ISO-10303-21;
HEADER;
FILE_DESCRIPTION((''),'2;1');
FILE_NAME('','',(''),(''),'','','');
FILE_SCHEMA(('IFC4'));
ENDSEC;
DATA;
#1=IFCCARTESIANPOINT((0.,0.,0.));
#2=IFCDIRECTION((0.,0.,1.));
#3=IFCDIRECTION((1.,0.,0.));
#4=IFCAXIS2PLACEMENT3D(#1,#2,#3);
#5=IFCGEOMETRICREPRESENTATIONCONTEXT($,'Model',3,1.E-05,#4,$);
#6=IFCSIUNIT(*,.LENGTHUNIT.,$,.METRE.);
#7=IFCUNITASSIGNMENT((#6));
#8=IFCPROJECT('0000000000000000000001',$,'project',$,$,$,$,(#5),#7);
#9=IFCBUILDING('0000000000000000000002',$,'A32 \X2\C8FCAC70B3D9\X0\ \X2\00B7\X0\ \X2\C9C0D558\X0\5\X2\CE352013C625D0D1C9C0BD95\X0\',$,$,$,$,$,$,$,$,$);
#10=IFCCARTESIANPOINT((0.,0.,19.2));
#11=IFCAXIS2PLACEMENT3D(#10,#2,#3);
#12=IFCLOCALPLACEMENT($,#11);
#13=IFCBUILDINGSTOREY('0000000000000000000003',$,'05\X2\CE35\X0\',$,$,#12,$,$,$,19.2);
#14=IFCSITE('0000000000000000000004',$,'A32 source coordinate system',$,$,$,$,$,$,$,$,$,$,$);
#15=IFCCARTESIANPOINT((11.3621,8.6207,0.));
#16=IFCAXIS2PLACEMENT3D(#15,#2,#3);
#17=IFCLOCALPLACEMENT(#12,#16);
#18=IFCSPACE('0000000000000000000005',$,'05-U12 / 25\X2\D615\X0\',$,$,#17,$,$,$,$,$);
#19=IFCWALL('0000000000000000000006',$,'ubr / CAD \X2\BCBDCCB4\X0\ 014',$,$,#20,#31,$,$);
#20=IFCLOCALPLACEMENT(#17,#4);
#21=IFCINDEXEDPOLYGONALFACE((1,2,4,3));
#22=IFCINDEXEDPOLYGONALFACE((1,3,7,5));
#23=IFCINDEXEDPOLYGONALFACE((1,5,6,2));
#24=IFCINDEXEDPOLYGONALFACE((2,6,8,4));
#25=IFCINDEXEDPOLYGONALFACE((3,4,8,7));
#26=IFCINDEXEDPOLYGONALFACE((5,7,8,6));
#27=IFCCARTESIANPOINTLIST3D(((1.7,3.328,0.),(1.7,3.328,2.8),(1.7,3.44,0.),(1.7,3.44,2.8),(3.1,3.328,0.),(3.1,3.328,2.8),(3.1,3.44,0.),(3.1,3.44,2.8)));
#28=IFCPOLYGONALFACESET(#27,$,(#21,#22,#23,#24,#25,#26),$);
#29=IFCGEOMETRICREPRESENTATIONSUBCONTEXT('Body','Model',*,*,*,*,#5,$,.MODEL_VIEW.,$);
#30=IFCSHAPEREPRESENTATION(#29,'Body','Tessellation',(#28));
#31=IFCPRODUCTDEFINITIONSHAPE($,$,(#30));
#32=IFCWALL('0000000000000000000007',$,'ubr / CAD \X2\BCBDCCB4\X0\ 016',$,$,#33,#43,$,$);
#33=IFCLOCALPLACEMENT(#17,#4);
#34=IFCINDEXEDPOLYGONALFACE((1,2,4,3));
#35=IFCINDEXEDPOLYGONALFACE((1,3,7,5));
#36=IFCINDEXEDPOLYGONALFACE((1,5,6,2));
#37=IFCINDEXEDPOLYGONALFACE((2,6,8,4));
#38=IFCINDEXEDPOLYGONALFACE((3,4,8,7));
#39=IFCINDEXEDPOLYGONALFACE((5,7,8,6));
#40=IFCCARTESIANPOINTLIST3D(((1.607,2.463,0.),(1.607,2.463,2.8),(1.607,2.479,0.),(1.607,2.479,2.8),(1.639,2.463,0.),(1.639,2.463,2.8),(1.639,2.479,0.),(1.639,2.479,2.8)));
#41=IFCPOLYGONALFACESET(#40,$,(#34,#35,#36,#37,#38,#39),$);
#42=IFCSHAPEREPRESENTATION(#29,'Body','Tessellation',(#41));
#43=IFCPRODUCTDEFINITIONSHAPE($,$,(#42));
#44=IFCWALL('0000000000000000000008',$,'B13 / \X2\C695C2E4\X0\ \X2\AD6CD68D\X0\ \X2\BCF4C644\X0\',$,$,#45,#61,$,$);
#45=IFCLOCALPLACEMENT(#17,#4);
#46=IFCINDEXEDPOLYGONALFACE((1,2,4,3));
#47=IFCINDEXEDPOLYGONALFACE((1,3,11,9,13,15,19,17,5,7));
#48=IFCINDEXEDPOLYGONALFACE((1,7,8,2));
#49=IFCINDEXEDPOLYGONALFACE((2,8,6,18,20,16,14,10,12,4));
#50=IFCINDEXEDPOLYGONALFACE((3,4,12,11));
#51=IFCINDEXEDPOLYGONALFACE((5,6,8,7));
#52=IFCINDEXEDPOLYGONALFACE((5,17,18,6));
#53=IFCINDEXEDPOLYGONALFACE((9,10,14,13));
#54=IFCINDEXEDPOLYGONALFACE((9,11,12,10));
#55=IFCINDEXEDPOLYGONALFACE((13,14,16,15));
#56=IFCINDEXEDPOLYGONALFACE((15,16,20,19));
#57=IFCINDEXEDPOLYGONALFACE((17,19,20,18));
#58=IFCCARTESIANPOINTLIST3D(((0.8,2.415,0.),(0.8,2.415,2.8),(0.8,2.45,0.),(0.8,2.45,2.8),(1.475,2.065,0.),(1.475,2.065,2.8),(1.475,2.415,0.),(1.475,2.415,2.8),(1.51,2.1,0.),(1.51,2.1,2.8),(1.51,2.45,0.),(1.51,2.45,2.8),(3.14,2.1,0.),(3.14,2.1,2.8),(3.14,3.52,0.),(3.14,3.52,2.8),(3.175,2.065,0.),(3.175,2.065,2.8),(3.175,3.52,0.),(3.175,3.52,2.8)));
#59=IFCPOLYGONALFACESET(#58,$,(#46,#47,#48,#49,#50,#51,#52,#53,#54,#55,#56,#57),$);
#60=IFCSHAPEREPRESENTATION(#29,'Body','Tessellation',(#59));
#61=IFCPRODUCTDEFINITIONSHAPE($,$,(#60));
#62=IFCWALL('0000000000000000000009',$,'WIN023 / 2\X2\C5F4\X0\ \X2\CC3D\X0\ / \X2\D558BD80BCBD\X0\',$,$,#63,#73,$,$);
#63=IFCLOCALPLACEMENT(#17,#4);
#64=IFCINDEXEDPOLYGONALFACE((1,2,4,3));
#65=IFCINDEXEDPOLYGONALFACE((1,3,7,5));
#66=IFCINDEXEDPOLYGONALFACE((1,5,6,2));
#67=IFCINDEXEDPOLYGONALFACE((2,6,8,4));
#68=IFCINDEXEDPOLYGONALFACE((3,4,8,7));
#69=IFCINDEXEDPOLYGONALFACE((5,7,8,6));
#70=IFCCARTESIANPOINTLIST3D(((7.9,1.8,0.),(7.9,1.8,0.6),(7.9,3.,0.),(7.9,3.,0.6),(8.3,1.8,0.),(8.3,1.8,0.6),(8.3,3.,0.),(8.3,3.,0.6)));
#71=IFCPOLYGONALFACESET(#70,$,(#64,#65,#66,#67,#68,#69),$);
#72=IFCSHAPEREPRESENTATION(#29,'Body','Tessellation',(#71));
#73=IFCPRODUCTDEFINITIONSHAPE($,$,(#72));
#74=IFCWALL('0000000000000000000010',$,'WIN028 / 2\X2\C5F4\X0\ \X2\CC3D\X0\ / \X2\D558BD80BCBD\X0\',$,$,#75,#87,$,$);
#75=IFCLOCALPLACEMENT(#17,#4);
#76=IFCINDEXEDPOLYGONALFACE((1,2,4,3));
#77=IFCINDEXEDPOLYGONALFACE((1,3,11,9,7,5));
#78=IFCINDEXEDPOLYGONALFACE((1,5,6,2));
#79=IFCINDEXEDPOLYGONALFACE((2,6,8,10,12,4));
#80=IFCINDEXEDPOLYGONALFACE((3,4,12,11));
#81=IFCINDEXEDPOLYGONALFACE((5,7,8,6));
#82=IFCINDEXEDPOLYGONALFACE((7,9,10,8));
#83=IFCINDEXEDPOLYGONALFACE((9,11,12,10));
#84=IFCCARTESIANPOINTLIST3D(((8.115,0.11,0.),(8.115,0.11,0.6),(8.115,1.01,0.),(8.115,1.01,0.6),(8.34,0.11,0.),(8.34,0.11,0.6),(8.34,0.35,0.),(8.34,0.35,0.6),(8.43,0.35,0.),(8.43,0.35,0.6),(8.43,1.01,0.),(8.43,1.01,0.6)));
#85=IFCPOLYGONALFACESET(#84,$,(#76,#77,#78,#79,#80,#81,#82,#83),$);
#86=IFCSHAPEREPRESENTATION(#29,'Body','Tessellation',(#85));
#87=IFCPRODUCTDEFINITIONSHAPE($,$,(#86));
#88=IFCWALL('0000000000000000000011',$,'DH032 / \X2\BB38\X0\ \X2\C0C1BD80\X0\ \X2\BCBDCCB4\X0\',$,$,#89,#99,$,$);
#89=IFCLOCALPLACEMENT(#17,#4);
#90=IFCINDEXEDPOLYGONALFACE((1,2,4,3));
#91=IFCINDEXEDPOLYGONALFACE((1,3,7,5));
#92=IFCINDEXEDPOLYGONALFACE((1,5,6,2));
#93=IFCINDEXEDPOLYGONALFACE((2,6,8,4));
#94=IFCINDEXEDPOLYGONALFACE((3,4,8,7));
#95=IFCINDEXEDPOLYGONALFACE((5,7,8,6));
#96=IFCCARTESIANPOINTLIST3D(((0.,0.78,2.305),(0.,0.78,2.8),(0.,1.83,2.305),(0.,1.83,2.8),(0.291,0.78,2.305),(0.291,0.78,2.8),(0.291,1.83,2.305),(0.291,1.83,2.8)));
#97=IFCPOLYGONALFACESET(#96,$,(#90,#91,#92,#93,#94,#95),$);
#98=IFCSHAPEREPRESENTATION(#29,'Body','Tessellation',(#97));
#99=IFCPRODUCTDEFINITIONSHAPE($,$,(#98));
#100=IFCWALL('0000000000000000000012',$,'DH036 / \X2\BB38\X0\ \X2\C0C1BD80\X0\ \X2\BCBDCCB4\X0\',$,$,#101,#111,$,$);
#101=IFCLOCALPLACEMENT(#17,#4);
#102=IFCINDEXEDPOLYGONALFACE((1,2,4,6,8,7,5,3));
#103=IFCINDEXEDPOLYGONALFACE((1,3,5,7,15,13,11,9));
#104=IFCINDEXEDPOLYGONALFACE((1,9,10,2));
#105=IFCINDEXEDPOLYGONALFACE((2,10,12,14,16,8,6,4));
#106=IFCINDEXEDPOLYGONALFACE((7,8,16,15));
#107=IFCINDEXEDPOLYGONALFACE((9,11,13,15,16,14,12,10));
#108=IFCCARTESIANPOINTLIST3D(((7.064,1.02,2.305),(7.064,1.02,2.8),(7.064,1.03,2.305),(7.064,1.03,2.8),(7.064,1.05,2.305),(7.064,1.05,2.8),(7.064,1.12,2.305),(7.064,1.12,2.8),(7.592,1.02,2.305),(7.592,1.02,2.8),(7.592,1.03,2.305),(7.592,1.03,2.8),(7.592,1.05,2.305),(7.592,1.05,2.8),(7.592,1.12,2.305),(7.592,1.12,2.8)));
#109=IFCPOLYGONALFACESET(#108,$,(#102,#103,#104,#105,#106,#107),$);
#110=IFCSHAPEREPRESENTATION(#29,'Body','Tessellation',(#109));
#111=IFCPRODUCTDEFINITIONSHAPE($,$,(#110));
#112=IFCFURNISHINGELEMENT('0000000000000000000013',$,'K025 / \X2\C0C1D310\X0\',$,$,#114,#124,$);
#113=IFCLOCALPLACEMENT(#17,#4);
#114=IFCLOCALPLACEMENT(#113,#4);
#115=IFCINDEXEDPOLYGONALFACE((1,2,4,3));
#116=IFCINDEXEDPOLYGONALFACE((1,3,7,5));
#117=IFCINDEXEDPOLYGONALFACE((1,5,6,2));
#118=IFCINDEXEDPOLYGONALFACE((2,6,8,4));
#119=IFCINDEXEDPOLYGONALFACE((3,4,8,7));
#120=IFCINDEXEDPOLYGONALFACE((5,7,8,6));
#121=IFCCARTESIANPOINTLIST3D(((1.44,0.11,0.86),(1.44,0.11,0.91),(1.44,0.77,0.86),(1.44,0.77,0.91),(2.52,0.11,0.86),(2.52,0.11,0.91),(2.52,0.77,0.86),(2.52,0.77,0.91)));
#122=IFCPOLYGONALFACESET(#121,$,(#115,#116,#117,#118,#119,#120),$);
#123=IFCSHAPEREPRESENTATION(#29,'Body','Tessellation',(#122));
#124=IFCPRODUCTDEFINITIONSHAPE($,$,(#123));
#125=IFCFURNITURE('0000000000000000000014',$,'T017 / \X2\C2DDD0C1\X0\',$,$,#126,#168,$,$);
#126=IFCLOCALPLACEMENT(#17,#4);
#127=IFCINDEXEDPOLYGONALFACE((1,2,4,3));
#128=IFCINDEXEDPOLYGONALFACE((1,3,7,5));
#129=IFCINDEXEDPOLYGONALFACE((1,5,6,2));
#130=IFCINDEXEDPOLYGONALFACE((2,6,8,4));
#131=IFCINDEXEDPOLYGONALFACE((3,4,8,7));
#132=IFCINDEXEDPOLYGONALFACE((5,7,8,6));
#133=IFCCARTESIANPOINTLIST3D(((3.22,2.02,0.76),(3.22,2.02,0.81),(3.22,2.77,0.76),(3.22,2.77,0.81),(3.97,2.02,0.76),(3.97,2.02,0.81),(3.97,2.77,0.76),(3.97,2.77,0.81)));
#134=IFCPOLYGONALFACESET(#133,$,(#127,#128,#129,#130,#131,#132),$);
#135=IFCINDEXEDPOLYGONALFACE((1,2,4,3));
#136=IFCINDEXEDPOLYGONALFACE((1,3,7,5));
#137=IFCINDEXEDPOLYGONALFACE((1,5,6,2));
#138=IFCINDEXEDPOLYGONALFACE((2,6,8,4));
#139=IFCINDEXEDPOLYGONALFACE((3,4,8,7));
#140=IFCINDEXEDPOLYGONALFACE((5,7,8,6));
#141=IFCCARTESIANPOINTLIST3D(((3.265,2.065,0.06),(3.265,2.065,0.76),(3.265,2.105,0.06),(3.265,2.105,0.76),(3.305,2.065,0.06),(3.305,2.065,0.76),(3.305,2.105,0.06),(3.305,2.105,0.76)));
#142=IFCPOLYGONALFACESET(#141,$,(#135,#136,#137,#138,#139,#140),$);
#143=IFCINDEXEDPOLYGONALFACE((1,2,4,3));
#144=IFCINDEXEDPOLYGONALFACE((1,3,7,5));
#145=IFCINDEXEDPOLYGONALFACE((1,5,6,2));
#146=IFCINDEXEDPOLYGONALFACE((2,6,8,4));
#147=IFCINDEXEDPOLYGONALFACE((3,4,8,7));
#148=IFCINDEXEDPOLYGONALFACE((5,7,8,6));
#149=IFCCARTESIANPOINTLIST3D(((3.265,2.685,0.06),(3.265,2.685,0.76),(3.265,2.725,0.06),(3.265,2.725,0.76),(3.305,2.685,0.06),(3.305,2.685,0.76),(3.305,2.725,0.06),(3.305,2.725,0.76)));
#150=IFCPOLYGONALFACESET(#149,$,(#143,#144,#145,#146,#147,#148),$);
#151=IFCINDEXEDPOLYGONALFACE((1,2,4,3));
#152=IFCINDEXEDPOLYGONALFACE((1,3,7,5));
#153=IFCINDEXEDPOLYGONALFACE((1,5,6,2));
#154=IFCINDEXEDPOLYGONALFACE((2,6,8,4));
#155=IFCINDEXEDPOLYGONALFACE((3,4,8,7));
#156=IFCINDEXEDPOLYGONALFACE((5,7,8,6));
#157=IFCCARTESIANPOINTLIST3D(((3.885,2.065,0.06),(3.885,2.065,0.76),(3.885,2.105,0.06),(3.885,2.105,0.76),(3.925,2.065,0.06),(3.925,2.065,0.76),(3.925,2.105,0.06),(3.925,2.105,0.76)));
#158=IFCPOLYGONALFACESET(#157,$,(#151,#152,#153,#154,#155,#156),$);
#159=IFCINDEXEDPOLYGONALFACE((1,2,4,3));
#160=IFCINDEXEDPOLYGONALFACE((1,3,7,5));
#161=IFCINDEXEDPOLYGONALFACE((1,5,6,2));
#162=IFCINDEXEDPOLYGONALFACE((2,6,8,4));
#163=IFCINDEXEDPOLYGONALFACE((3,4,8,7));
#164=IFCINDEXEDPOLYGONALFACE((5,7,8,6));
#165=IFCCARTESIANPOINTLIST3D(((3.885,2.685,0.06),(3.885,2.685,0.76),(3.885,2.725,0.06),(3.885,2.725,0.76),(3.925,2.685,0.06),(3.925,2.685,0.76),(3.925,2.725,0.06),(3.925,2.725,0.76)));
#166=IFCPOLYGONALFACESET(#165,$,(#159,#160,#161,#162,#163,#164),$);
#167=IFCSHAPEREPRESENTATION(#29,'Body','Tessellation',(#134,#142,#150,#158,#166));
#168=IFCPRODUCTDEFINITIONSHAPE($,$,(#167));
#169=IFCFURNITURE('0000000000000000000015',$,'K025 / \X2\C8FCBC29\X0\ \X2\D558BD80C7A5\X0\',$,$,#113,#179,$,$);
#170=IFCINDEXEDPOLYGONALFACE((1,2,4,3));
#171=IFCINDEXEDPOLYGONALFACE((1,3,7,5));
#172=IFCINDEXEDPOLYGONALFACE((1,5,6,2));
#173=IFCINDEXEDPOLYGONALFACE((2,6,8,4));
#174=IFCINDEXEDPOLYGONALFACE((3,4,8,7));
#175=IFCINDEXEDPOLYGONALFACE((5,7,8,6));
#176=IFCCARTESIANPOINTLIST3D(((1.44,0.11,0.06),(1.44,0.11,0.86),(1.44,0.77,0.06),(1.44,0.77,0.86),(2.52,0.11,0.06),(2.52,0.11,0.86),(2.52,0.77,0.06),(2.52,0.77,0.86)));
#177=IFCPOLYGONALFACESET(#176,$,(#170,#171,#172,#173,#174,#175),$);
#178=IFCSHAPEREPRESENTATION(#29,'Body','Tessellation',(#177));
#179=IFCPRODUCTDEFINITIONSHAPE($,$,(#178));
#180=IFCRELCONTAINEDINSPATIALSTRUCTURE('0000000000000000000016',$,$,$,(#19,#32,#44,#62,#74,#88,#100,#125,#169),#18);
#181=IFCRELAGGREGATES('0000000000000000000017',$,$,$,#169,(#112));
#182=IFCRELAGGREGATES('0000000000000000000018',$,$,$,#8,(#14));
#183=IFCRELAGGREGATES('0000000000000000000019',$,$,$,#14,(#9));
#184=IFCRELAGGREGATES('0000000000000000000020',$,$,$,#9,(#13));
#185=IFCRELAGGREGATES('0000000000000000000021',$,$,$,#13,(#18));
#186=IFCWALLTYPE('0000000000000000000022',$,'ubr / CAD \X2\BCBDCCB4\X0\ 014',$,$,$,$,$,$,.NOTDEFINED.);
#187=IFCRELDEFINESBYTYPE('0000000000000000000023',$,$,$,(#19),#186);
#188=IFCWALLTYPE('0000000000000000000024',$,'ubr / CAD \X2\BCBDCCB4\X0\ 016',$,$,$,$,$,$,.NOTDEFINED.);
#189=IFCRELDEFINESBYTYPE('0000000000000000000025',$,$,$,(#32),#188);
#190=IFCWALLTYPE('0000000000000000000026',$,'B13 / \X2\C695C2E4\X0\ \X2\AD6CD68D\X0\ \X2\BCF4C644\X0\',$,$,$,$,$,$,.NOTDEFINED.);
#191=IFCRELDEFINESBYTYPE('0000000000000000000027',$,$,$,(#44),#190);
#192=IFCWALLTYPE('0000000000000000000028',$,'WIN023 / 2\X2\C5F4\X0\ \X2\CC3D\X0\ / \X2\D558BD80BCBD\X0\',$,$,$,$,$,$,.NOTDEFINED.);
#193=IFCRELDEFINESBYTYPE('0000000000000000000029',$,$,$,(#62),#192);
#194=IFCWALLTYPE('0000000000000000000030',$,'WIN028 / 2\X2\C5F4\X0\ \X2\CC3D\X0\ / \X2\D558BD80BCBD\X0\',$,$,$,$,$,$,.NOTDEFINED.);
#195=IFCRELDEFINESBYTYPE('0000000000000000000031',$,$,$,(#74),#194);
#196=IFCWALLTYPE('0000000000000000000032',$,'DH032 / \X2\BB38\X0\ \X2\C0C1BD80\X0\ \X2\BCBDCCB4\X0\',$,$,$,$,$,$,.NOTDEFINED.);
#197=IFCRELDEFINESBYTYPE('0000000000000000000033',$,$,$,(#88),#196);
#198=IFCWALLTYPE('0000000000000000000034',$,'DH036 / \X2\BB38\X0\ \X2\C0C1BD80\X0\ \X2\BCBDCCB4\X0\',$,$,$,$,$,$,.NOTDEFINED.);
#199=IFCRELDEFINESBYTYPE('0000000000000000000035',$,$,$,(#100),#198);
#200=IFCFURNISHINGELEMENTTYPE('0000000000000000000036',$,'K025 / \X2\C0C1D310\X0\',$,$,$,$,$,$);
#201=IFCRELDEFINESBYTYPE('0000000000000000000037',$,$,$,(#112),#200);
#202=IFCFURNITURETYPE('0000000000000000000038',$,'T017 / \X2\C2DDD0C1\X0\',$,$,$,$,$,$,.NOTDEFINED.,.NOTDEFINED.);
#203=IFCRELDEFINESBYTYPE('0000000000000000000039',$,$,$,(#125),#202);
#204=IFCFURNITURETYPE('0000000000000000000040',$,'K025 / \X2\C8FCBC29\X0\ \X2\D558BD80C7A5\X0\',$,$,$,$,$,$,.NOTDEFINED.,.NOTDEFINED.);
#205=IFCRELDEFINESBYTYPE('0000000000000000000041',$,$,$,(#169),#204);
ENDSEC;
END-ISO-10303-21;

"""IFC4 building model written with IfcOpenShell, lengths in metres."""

from ifc_helpers import new_model, si_unit, frame, origin, origin_with_axes, place, context, subcontext, project, spatial, polyline, outline, extrude, source, transform, mapped, type_object, type_shapes, element, aggregate, save


model = new_model("IFC4")

# Units and contexts
model_context = context("Model", 3, precision=1e-05, world=origin_with_axes())
body_context = subcontext(model_context, "Body", "Model", "MODEL_VIEW")
ifc_project = project(units=[si_unit("LENGTHUNIT", "METRE")], contexts=[model_context])

# Site, building, storey, space
site = spatial("IfcSite", under=ifc_project, Name="A32 source coordinate system")
building = spatial("IfcBuilding", under=site, Name="A32 주거동 · 지하5층–옥탑지붕")
storey_placement = place(None, frame((0.0, 0.0, 19.2), z_axis=(0.0, 0.0, 1.0), x_axis=(1.0, 0.0, 0.0)))
storey = spatial("IfcBuildingStorey", under=building, at=storey_placement, Name="05층", Elevation=19.2)
space_1_placement = place(storey_placement, frame((11.3621, 8.6207, 0.0), z_axis=(0.0, 0.0, 1.0), x_axis=(1.0, 0.0, 0.0)))
space_1 = spatial("IfcSpace", under=storey, at=space_1_placement, Name="05-U12 / 25형")

# Walls
wall_type_1 = type_object("IfcWallType", Name="ubr / CAD 벽체 014", PredefinedType="NOTDEFINED")
shared_shape_1 = source(origin(), body_context, "Body", "SweptSolid", [
    extrude(outline(polyline([(3.1, 3.44), (3.1, 3.328), (1.7, 3.328), (1.7, 3.44), (3.1, 3.44)])), origin(), (0.0, 0.0, 1.0), 2.8),
])
type_shapes(wall_type_1, [shared_shape_1])
wall_1_placement = place(space_1_placement, origin_with_axes())
element("IfcWall", 1, at=wall_1_placement, inside=space_1, type_object=wall_type_1, Name="ubr / CAD 벽체 014", context=body_context, shape_type="MappedRepresentation", body=[
    mapped(shared_shape_1, transform((0.0, 0.0, 0.0), scale=1.0)),
])
wall_type_2 = type_object("IfcWallType", Name="ubr / CAD 벽체 016", PredefinedType="NOTDEFINED")
shared_shape_2 = source(origin(), body_context, "Body", "SweptSolid", [
    extrude(outline(polyline([(1.639, 2.479), (1.639, 2.463), (1.607, 2.463), (1.607, 2.479), (1.639, 2.479)])), origin(), (0.0, 0.0, 1.0), 2.8),
])
type_shapes(wall_type_2, [shared_shape_2])
wall_2_placement = place(space_1_placement, origin_with_axes())
element("IfcWall", 2, at=wall_2_placement, inside=space_1, type_object=wall_type_2, Name="ubr / CAD 벽체 016", context=body_context, shape_type="MappedRepresentation", body=[
    mapped(shared_shape_2, transform((0.0, 0.0, 0.0), scale=1.0)),
])
wall_type_3 = type_object("IfcWallType", Name="B13 / 욕실 구획 보완", PredefinedType="NOTDEFINED")
shared_shape_3 = source(origin(), body_context, "Body", "SweptSolid", [
    extrude(outline(polyline([(0.8, 2.45), (1.51, 2.45), (1.51, 2.1), (3.14, 2.1), (3.14, 3.52), (3.175, 3.52), (3.175, 2.065), (1.475, 2.065), (1.475, 2.415), (0.8, 2.415), (0.8, 2.45)])), origin(), (0.0, 0.0, 1.0), 2.8),
])
type_shapes(wall_type_3, [shared_shape_3])
wall_3_placement = place(space_1_placement, origin_with_axes())
element("IfcWall", 3, at=wall_3_placement, inside=space_1, type_object=wall_type_3, Name="B13 / 욕실 구획 보완", context=body_context, shape_type="MappedRepresentation", body=[
    mapped(shared_shape_3, transform((0.0, 0.0, 0.0), scale=1.0)),
])
wall_type_4 = type_object("IfcWallType", Name="WIN023 / 2열 창 / 하부벽", PredefinedType="NOTDEFINED")
shared_shape_4 = source(origin(), body_context, "Body", "SweptSolid", [
    extrude(outline(polyline([(7.9, 1.8), (7.9, 3.0), (8.3, 3.0), (8.3, 1.8), (7.9, 1.8)])), origin(), (0.0, 0.0, 1.0), 0.6),
])
type_shapes(wall_type_4, [shared_shape_4])
wall_4_placement = place(space_1_placement, origin_with_axes())
element("IfcWall", 4, at=wall_4_placement, inside=space_1, type_object=wall_type_4, Name="WIN023 / 2열 창 / 하부벽", context=body_context, shape_type="MappedRepresentation", body=[
    mapped(shared_shape_4, transform((0.0, 0.0, 0.0), scale=1.0)),
])
wall_type_5 = type_object("IfcWallType", Name="WIN028 / 2열 창 / 하부벽", PredefinedType="NOTDEFINED")
shared_shape_5 = source(origin(), body_context, "Body", "SweptSolid", [
    extrude(outline(polyline([(8.34, 0.35), (8.34, 0.11), (8.115, 0.11), (8.115, 1.01), (8.43, 1.01), (8.43, 0.35), (8.34, 0.35)])), origin(), (0.0, 0.0, 1.0), 0.6),
])
type_shapes(wall_type_5, [shared_shape_5])
wall_5_placement = place(space_1_placement, origin_with_axes())
element("IfcWall", 5, at=wall_5_placement, inside=space_1, type_object=wall_type_5, Name="WIN028 / 2열 창 / 하부벽", context=body_context, shape_type="MappedRepresentation", body=[
    mapped(shared_shape_5, transform((0.0, 0.0, 0.0), scale=1.0)),
])
wall_type_6 = type_object("IfcWallType", Name="DH032 / 문 상부 벽체", PredefinedType="NOTDEFINED")
shared_shape_6 = source(origin(), body_context, "Body", "SweptSolid", [
    extrude(outline(polyline([(0.0, 1.83), (0.291, 1.83), (0.291, 0.78), (0.0, 0.78), (0.0, 1.83)])), frame((0.0, 0.0, 2.305)), (0.0, 0.0, 1.0), 0.495),
])
type_shapes(wall_type_6, [shared_shape_6])
wall_6_placement = place(space_1_placement, origin_with_axes())
element("IfcWall", 6, at=wall_6_placement, inside=space_1, type_object=wall_type_6, Name="DH032 / 문 상부 벽체", context=body_context, shape_type="MappedRepresentation", body=[
    mapped(shared_shape_6, transform((0.0, 0.0, 0.0), scale=1.0)),
])
wall_type_7 = type_object("IfcWallType", Name="DH036 / 문 상부 벽체", PredefinedType="NOTDEFINED")
shared_shape_7 = source(origin(), body_context, "Body", "SweptSolid", [
    extrude(outline(polyline([(7.064, 1.03), (7.064, 1.05), (7.064, 1.12), (7.592, 1.12), (7.592, 1.05), (7.592, 1.03), (7.592, 1.02), (7.064, 1.02), (7.064, 1.03)])), frame((0.0, 0.0, 2.305)), (0.0, 0.0, 1.0), 0.495),
])
type_shapes(wall_type_7, [shared_shape_7])
wall_7_placement = place(space_1_placement, origin_with_axes())
element("IfcWall", 7, at=wall_7_placement, inside=space_1, type_object=wall_type_7, Name="DH036 / 문 상부 벽체", context=body_context, shape_type="MappedRepresentation", body=[
    mapped(shared_shape_7, transform((0.0, 0.0, 0.0), scale=1.0)),
])

# Furnishing element
furnishing_element_type_1 = type_object("IfcFurnishingElementType", Name="K025 / 상판")
shared_shape_8 = source(origin(), body_context, "Body", "SweptSolid", [
    extrude(outline(polyline([(2.52, 0.77), (2.52, 0.11), (1.44, 0.11), (1.44, 0.77), (2.52, 0.77)])), frame((0.0, 0.0, 0.86)), (0.0, 0.0, 1.0), 0.05),
])
type_shapes(furnishing_element_type_1, [shared_shape_8])
furniture_1_placement = place(space_1_placement, origin_with_axes())
furnishing_1_placement = place(furniture_1_placement, origin_with_axes())
furnishing_1 = element("IfcFurnishingElement", 8, at=furnishing_1_placement, type_object=furnishing_element_type_1, Name="K025 / 상판", context=body_context, shape_type="MappedRepresentation", body=[
    mapped(shared_shape_8, transform((0.0, 0.0, 0.0), scale=1.0)),
])

# Furniture
furniture_type_1 = type_object("IfcFurnitureType", Name="T017 / 식탁", AssemblyPlace="NOTDEFINED", PredefinedType="NOTDEFINED")
shared_shape_9 = source(origin(), body_context, "Body", "SweptSolid", [
    extrude(outline(polyline([(3.97, 2.02), (3.22, 2.02), (3.22, 2.77), (3.97, 2.77), (3.97, 2.02)])), frame((0.0, 0.0, 0.76)), (0.0, 0.0, 1.0), 0.05),
    extrude(outline(polyline([(3.265, 2.065), (3.265, 2.105), (3.305, 2.105), (3.305, 2.065), (3.265, 2.065)])), frame((0.0, 0.0, 0.06)), (0.0, 0.0, 1.0), 0.7),
    extrude(outline(polyline([(3.265, 2.685), (3.265, 2.725), (3.305, 2.725), (3.305, 2.685), (3.265, 2.685)])), frame((0.0, 0.0, 0.06)), (0.0, 0.0, 1.0), 0.7),
    extrude(outline(polyline([(3.885, 2.065), (3.885, 2.105), (3.925, 2.105), (3.925, 2.065), (3.885, 2.065)])), frame((0.0, 0.0, 0.06)), (0.0, 0.0, 1.0), 0.7),
    extrude(outline(polyline([(3.885, 2.685), (3.885, 2.725), (3.925, 2.725), (3.925, 2.685), (3.885, 2.685)])), frame((0.0, 0.0, 0.06)), (0.0, 0.0, 1.0), 0.7),
])
type_shapes(furniture_type_1, [shared_shape_9])
furniture_2_placement = place(space_1_placement, origin_with_axes())
element("IfcFurniture", 9, at=furniture_2_placement, inside=space_1, type_object=furniture_type_1, Name="T017 / 식탁", context=body_context, shape_type="MappedRepresentation", body=[
    mapped(shared_shape_9, transform((0.0, 0.0, 0.0), scale=1.0)),
])
furniture_type_2 = type_object("IfcFurnitureType", Name="K025 / 주방 하부장", AssemblyPlace="NOTDEFINED", PredefinedType="NOTDEFINED")
shared_shape_10 = source(origin(), body_context, "Body", "SweptSolid", [
    extrude(outline(polyline([(1.44, 0.77), (2.52, 0.77), (2.52, 0.11), (1.44, 0.11), (1.44, 0.77)])), frame((0.0, 0.0, 0.06)), (0.0, 0.0, 1.0), 0.8),
])
type_shapes(furniture_type_2, [shared_shape_10])
furniture_1 = element("IfcFurniture", 10, at=furniture_1_placement, inside=space_1, type_object=furniture_type_2, Name="K025 / 주방 하부장", context=body_context, shape_type="MappedRepresentation", body=[
    mapped(shared_shape_10, transform((0.0, 0.0, 0.0), scale=1.0)),
])
aggregate(furniture_1, [furnishing_1])

save(model, "model.ifc")
